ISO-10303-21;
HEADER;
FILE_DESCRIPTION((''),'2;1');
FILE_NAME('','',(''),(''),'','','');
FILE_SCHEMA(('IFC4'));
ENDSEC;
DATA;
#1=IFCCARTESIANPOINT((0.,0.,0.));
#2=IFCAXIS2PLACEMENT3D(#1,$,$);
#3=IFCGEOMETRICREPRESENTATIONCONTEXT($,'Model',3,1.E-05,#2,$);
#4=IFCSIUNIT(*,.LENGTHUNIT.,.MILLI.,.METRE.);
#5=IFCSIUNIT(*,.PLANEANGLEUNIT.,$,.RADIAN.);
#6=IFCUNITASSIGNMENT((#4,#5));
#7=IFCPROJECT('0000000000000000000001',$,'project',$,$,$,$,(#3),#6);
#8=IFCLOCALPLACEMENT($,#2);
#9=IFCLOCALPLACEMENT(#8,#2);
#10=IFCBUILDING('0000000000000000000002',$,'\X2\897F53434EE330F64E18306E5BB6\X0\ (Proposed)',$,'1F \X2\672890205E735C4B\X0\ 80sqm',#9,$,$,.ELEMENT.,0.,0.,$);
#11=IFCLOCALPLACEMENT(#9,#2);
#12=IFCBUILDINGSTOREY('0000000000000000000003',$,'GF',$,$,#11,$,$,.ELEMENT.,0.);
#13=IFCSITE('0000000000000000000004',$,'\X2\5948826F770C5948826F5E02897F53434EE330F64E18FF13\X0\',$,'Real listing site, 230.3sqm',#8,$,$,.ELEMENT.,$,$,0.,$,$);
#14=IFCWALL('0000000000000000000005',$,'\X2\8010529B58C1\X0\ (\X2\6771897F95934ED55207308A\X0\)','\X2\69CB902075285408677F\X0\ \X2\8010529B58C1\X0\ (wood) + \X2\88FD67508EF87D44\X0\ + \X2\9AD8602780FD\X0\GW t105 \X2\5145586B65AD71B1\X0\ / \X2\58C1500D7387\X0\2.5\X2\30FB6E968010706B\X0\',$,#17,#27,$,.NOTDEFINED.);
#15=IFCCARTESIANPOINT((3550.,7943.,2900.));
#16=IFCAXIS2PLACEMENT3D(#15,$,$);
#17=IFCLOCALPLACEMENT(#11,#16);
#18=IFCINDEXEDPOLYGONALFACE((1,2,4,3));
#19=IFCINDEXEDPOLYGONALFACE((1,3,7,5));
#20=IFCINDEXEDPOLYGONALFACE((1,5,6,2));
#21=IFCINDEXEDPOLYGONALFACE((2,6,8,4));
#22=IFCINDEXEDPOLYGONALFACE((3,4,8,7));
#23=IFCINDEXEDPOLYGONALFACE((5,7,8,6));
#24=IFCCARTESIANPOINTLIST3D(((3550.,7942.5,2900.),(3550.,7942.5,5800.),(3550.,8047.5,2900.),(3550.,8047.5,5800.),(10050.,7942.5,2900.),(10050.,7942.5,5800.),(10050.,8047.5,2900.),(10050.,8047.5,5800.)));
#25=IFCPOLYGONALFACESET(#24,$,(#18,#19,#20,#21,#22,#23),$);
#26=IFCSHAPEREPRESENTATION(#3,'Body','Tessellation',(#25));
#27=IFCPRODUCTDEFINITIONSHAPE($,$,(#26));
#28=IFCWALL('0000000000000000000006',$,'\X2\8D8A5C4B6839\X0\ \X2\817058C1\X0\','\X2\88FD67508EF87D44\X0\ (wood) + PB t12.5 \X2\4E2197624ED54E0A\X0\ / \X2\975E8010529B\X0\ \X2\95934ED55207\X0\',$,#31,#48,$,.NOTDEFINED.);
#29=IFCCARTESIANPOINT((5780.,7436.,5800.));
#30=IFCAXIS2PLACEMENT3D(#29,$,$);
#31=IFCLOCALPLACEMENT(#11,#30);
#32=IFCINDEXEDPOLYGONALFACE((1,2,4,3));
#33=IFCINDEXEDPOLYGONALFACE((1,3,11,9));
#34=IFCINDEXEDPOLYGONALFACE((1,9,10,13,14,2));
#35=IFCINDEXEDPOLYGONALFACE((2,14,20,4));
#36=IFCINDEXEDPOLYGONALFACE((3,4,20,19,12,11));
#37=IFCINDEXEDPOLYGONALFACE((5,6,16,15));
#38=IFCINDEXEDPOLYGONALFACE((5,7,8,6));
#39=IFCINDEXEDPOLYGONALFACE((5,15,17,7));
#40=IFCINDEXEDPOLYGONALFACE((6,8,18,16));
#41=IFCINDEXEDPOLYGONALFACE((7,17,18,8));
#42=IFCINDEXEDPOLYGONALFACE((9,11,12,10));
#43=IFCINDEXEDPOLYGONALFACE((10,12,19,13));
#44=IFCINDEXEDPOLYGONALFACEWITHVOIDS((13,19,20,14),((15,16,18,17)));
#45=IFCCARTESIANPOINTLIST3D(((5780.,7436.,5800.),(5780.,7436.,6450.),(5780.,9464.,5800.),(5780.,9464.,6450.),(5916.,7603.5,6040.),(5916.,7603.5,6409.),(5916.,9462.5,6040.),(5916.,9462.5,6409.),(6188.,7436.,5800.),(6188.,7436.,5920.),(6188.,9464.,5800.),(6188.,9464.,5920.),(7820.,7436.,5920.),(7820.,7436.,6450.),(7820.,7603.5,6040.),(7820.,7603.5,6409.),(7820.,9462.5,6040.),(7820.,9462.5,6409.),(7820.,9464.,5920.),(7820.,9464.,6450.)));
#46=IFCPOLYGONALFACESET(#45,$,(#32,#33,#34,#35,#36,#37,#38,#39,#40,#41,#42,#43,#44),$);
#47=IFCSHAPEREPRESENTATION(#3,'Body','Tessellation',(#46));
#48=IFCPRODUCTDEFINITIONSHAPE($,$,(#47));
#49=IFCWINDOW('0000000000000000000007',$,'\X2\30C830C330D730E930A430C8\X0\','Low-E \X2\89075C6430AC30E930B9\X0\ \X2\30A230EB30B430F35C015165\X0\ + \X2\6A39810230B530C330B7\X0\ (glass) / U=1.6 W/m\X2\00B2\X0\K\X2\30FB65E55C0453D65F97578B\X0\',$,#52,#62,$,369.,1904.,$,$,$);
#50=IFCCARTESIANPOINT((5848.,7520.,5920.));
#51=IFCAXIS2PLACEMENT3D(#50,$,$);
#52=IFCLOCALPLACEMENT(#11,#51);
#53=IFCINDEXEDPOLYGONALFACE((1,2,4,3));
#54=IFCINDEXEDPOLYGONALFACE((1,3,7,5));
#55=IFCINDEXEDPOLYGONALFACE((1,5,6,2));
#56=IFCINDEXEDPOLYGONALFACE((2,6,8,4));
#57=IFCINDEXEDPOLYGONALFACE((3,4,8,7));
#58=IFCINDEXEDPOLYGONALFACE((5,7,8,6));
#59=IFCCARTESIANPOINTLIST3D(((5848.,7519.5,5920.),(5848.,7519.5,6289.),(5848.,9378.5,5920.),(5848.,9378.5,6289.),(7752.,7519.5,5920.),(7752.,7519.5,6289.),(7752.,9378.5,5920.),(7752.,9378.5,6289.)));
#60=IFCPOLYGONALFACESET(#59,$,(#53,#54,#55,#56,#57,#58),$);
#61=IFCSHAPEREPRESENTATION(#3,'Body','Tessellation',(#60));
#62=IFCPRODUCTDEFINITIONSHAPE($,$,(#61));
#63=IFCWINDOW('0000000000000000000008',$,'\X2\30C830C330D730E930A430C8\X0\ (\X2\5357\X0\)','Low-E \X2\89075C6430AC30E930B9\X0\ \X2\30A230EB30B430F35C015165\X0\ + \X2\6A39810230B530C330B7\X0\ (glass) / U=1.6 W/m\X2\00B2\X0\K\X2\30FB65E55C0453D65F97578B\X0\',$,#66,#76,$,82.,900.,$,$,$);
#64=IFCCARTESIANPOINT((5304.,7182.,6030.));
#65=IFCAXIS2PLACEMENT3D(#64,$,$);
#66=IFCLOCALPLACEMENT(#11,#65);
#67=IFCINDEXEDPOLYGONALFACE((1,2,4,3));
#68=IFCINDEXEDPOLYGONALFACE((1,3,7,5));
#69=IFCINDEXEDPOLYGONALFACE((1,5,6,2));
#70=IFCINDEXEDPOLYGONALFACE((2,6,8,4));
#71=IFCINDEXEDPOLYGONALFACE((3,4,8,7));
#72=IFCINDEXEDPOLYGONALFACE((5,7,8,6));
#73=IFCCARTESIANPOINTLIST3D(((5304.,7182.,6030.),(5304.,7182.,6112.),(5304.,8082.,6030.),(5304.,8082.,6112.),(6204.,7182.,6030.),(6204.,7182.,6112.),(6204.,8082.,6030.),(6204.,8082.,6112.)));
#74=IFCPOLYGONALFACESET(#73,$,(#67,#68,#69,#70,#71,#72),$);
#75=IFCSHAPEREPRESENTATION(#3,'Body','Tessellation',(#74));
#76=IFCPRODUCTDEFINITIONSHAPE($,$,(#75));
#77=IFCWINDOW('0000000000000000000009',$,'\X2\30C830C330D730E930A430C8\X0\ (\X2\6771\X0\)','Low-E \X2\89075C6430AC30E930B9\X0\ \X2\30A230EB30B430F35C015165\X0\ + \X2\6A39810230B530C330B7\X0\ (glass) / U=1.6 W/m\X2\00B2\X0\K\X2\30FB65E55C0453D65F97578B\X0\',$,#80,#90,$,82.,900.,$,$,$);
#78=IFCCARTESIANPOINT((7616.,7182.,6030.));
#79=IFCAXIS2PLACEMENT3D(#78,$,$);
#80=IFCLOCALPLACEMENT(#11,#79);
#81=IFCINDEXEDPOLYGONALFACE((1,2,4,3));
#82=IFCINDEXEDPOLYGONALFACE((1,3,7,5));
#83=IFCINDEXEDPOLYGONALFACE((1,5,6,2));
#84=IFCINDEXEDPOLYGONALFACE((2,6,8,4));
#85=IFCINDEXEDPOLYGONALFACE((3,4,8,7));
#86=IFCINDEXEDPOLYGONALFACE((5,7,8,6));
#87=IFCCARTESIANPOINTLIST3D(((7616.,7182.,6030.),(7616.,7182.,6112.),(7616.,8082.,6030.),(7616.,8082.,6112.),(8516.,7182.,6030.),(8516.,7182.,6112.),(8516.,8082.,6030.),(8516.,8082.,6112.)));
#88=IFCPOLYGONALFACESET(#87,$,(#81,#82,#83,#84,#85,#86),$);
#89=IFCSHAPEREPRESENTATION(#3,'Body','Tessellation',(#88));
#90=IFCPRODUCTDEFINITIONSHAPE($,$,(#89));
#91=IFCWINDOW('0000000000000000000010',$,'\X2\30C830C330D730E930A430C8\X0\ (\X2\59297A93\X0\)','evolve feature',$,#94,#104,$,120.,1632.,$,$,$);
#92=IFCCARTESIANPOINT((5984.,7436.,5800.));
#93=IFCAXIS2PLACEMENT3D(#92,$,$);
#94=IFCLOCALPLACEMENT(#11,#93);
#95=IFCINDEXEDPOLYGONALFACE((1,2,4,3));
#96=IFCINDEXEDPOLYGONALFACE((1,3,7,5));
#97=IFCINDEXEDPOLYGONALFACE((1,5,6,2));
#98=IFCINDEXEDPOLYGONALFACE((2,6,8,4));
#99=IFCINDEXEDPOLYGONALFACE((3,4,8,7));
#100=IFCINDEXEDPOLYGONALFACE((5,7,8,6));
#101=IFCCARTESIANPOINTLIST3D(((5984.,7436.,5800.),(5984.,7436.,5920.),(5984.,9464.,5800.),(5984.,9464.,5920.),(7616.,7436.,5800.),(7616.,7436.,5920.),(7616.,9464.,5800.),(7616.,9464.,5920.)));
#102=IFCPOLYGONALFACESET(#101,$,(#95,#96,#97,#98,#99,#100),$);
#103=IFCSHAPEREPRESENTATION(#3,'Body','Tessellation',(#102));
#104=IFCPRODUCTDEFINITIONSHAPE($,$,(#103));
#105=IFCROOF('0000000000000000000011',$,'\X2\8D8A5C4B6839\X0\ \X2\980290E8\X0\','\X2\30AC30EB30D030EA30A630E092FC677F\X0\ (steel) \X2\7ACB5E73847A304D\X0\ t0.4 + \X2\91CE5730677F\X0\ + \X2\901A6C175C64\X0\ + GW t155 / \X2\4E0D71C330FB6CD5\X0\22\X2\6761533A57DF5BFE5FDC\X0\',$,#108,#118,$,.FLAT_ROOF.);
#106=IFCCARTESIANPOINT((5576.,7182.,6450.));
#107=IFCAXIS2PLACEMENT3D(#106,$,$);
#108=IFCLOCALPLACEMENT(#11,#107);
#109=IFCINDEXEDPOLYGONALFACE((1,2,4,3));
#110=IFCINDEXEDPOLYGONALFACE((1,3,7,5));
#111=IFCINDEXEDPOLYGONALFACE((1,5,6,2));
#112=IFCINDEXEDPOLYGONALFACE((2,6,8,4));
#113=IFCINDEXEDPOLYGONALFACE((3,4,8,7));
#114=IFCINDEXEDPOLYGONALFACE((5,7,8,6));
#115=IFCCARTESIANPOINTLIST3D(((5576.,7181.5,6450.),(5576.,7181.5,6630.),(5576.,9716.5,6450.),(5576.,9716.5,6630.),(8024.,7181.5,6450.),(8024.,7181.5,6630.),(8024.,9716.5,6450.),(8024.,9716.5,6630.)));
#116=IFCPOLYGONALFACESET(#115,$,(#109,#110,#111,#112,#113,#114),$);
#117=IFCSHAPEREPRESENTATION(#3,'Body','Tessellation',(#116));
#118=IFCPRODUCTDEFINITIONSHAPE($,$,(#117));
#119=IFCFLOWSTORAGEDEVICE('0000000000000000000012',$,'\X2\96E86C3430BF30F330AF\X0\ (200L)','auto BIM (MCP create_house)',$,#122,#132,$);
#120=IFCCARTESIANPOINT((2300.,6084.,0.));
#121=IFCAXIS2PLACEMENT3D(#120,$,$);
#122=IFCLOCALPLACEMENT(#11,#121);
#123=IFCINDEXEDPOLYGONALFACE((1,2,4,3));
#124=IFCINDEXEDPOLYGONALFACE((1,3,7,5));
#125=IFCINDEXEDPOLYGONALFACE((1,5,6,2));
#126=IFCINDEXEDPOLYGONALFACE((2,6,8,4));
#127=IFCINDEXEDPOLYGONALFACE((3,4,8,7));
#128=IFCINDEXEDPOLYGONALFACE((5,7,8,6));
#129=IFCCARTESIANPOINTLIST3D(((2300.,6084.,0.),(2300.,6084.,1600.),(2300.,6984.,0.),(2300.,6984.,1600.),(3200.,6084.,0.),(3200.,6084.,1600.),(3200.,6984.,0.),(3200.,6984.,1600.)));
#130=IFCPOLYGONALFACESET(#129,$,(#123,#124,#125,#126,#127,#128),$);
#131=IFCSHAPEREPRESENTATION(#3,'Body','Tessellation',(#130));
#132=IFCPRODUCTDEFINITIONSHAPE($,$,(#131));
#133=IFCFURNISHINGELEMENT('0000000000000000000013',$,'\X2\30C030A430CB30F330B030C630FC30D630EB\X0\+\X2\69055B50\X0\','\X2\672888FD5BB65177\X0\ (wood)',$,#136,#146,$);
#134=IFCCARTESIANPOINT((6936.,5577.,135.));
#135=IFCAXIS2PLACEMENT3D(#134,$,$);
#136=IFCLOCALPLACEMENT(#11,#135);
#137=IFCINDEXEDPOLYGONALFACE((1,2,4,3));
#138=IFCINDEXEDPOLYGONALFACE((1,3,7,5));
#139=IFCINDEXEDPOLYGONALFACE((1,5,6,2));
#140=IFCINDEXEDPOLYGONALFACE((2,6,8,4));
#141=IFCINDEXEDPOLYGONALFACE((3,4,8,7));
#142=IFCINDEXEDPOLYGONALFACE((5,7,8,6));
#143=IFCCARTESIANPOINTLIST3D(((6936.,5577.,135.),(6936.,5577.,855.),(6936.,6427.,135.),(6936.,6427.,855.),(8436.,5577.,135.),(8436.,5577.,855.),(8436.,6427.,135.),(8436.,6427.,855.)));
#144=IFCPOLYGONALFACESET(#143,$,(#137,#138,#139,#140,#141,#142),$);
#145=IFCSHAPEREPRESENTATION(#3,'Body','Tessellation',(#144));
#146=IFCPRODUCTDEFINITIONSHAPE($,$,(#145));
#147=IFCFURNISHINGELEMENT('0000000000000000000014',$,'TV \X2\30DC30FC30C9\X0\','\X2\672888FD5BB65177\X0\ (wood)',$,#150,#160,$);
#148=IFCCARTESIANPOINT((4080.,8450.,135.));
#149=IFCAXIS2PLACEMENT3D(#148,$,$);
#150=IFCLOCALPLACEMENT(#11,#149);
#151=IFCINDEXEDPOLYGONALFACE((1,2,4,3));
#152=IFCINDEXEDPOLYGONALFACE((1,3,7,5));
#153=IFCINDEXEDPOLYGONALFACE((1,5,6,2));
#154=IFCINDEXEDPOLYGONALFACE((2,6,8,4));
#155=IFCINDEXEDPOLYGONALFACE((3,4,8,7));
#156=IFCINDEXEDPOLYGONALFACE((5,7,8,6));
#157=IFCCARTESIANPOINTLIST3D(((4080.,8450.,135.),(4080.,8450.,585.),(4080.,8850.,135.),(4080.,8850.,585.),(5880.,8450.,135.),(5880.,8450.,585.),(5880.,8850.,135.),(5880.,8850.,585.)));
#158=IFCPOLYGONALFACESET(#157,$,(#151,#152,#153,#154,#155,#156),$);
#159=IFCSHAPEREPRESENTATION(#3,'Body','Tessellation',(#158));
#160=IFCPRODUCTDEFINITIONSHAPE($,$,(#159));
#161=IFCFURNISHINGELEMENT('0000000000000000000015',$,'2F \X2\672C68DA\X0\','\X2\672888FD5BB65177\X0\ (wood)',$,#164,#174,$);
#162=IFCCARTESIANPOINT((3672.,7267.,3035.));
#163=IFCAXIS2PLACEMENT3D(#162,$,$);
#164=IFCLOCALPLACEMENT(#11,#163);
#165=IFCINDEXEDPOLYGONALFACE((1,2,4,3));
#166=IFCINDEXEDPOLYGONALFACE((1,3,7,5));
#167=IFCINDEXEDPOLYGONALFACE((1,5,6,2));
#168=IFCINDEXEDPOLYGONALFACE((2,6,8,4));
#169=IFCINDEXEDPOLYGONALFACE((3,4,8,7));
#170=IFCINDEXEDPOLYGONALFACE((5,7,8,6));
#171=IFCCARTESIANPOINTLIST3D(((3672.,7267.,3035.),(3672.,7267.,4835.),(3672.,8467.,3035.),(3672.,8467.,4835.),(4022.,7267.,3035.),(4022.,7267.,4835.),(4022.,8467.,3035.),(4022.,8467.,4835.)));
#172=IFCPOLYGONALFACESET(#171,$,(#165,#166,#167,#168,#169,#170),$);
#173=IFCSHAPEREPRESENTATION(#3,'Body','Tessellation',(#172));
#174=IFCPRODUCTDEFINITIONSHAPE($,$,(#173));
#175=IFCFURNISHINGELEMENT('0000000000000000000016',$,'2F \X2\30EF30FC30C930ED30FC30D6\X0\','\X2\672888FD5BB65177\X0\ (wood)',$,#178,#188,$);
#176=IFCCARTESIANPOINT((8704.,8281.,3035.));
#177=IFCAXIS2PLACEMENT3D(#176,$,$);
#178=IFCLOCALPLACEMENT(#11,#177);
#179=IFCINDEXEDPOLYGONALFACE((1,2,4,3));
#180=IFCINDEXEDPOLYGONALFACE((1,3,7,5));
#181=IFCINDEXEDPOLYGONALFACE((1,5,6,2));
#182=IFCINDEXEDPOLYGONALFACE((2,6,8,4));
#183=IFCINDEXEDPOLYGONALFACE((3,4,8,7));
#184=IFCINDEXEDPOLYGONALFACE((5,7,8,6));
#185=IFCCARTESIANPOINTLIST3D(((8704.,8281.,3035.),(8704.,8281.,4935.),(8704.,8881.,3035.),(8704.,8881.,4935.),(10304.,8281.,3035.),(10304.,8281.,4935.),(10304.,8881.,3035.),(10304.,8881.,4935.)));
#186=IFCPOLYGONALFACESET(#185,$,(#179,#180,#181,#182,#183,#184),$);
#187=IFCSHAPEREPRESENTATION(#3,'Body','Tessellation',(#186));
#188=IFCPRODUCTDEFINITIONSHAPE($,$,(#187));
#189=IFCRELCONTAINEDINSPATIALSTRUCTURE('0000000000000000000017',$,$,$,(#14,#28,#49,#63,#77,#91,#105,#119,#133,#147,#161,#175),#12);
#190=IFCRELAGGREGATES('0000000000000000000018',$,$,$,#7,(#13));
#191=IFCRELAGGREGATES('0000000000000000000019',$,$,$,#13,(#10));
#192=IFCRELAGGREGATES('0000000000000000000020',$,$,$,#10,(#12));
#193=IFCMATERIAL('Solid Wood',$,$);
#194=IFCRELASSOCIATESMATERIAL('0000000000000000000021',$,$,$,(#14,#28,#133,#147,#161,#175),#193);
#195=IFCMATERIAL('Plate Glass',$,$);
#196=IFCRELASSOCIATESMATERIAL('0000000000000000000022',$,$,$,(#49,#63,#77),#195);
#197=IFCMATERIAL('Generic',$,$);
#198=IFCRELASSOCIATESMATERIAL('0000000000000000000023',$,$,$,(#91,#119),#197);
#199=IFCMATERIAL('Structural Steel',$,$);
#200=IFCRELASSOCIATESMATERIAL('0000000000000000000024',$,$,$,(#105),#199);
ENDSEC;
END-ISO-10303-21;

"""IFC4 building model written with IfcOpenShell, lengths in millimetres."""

from ifc_helpers import new_model, si_unit, frame, frame_2d, origin, place, context, project, spatial, rectangle, extrude, material, element, fill, save


model = new_model("IFC4")

# Units and contexts
model_context = context("Model", 3, precision=1e-05, world=origin())
ifc_project = project(units=[si_unit("LENGTHUNIT", "METRE", prefix="MILLI"), si_unit("PLANEANGLEUNIT", "RADIAN")], contexts=[model_context])

# Site, building, storey
site_placement = place(None, origin())
site = spatial("IfcSite", under=ifc_project, at=site_placement, Name="奈良県奈良市西千代ヶ丘３", ObjectType="Real listing site, 230.3sqm", CompositionType="ELEMENT", RefElevation=0.0)
building_placement = place(site_placement, origin())
building = spatial("IfcBuilding", under=site, at=building_placement, Name="西千代ヶ丘の家 (Proposed)", ObjectType="1F 木造平屋 80sqm", CompositionType="ELEMENT", ElevationOfRefHeight=0.0, ElevationOfTerrain=0.0)
storey_placement = place(building_placement, origin())
storey = spatial("IfcBuildingStorey", under=building, at=storey_placement, Name="GF", CompositionType="ELEMENT", Elevation=0.0)

# Wall
ifc_material_1 = material(Name="Solid Wood")
wall_1_placement = place(storey_placement, frame((3550.0, 7943.0, 2900.0)))
element("IfcWall", 1, at=wall_1_placement, inside=storey, material=ifc_material_1, Name="耐力壁 (東西間仕切り)", Description="構造用合板 耐力壁 (wood) + 製材軸組 + 高性能GW t105 充填断熱 / 壁倍率2.5・準耐火", PredefinedType="NOTDEFINED", context=model_context, shape_type="SweptSolid", body=[
    extrude(rectangle(XDim=6500.0, YDim=105.0, at=frame_2d((3250.0, 52.0))), frame((3550.0, 7943.0, 2900.0)), (0.0, 0.0, 1.0), 2900.0),
])

# Wall, openings, windows
wall_2_placement = place(storey_placement, frame((5780.0, 7436.0, 5800.0)))
wall_2 = element("IfcWall", 2, at=wall_2_placement, inside=storey, material=ifc_material_1, Name="越屋根 腰壁", Description="製材軸組 (wood) + PB t12.5 両面仕上 / 非耐力 間仕切", PredefinedType="NOTDEFINED", context=model_context, shape_type="SweptSolid", body=[
    extrude(rectangle(XDim=2040.0, YDim=2028.0, at=frame_2d((1020.0, 1014.0))), frame((5780.0, 7436.0, 5800.0)), (0.0, 0.0, 1.0), 650.0),
])
opening_1_placement = place(storey_placement, frame((5848.0, 7520.0, 5920.0)))
opening_1 = element("IfcOpeningElement", 3, at=opening_1_placement, cuts=wall_2, PredefinedType="NOTDEFINED", context=model_context, shape_type="SweptSolid", body=[
    extrude(rectangle(XDim=1904.0, YDim=1859.0, at=frame_2d((952.0, 929.0))), frame((5848.0, 7520.0, 5920.0)), (0.0, 0.0, 1.0), 369.0),
])
opening_2_placement = place(storey_placement, frame((5304.0, 7182.0, 6030.0)))
opening_2 = element("IfcOpeningElement", 4, at=opening_2_placement, cuts=wall_2, PredefinedType="NOTDEFINED", context=model_context, shape_type="SweptSolid", body=[
    extrude(rectangle(XDim=900.0, YDim=900.0, at=frame_2d((450.0, 450.0))), frame((5304.0, 7182.0, 6030.0)), (0.0, 0.0, 1.0), 82.0),
])
opening_3_placement = place(storey_placement, frame((7616.0, 7182.0, 6030.0)))
opening_3 = element("IfcOpeningElement", 5, at=opening_3_placement, cuts=wall_2, PredefinedType="NOTDEFINED", context=model_context, shape_type="SweptSolid", body=[
    extrude(rectangle(XDim=900.0, YDim=900.0, at=frame_2d((450.0, 450.0))), frame((7616.0, 7182.0, 6030.0)), (0.0, 0.0, 1.0), 82.0),
])
opening_4_placement = place(storey_placement, frame((5984.0, 7436.0, 5800.0)))
opening_4 = element("IfcOpeningElement", 6, at=opening_4_placement, cuts=wall_2, PredefinedType="NOTDEFINED", context=model_context, shape_type="SweptSolid", body=[
    extrude(rectangle(XDim=1632.0, YDim=2028.0, at=frame_2d((816.0, 1014.0))), frame((5984.0, 7436.0, 5800.0)), (0.0, 0.0, 1.0), 120.0),
])
ifc_material_2 = material(Name="Plate Glass")
window_1_placement = place(storey_placement, frame((5848.0, 7520.0, 5920.0)))
window_1 = element("IfcWindow", 7, at=window_1_placement, inside=storey, material=ifc_material_2, Name="トップライト", Description="Low-E 複層ガラス アルゴン封入 + 樹脂サッシ (glass) / U=1.6 W/m²K・日射取得型", OverallHeight=369.0, OverallWidth=1904.0, context=model_context, shape_type="SweptSolid", body=[
    extrude(rectangle(XDim=1904.0, YDim=1859.0, at=frame_2d((952.0, 929.0))), frame((5848.0, 7520.0, 5920.0)), (0.0, 0.0, 1.0), 369.0),
])
fill(opening_1, window_1)
window_2_placement = place(storey_placement, frame((5304.0, 7182.0, 6030.0)))
window_2 = element("IfcWindow", 8, at=window_2_placement, inside=storey, material=ifc_material_2, Name="トップライト (南)", Description="Low-E 複層ガラス アルゴン封入 + 樹脂サッシ (glass) / U=1.6 W/m²K・日射取得型", OverallHeight=82.0, OverallWidth=900.0, context=model_context, shape_type="SweptSolid", body=[
    extrude(rectangle(XDim=900.0, YDim=900.0, at=frame_2d((450.0, 450.0))), frame((5304.0, 7182.0, 6030.0)), (0.0, 0.0, 1.0), 82.0),
])
fill(opening_2, window_2)
window_3_placement = place(storey_placement, frame((7616.0, 7182.0, 6030.0)))
window_3 = element("IfcWindow", 9, at=window_3_placement, inside=storey, material=ifc_material_2, Name="トップライト (東)", Description="Low-E 複層ガラス アルゴン封入 + 樹脂サッシ (glass) / U=1.6 W/m²K・日射取得型", OverallHeight=82.0, OverallWidth=900.0, context=model_context, shape_type="SweptSolid", body=[
    extrude(rectangle(XDim=900.0, YDim=900.0, at=frame_2d((450.0, 450.0))), frame((7616.0, 7182.0, 6030.0)), (0.0, 0.0, 1.0), 82.0),
])
fill(opening_3, window_3)
ifc_material_3 = material(Name="Generic")
window_4_placement = place(storey_placement, frame((5984.0, 7436.0, 5800.0)))
window_4 = element("IfcWindow", 10, at=window_4_placement, inside=storey, material=ifc_material_3, Name="トップライト (天窓)", Description="evolve feature", OverallHeight=120.0, OverallWidth=1632.0, context=model_context, shape_type="SweptSolid", body=[
    extrude(rectangle(XDim=1632.0, YDim=2028.0, at=frame_2d((816.0, 1014.0))), frame((5984.0, 7436.0, 5800.0)), (0.0, 0.0, 1.0), 120.0),
])
fill(opening_4, window_4)

# Roof
ifc_material_4 = material(Name="Structural Steel")
roof_placement = place(storey_placement, frame((5576.0, 7182.0, 6450.0)))
element("IfcRoof", 11, at=roof_placement, inside=storey, material=ifc_material_4, Name="越屋根 頂部", Description="ガルバリウム鋼板 (steel) 立平葺き t0.4 + 野地板 + 通気層 + GW t155 / 不燃・法22条区域対応", PredefinedType="FLAT_ROOF", context=model_context, shape_type="SweptSolid", body=[
    extrude(rectangle(XDim=2448.0, YDim=2535.0, at=frame_2d((1224.0, 1267.0))), frame((5576.0, 7182.0, 6450.0)), (0.0, 0.0, 1.0), 180.0),
])

# Flow storage device
flow_storage_device_placement = place(storey_placement, frame((2300.0, 6084.0, 0.0)))
element("IfcFlowStorageDevice", 12, at=flow_storage_device_placement, inside=storey, material=ifc_material_3, Name="雨水タンク (200L)", Description="auto BIM (MCP create_house)", context=model_context, shape_type="SweptSolid", body=[
    extrude(rectangle(XDim=900.0, YDim=900.0, at=frame_2d((450.0, 450.0))), frame((2300.0, 6084.0, 0.0)), (0.0, 0.0, 1.0), 1600.0),
])

# Furnishing elements
furnishing_1_placement = place(storey_placement, frame((6936.0, 5577.0, 135.0)))
element("IfcFurnishingElement", 13, at=furnishing_1_placement, inside=storey, material=ifc_material_1, Name="ダイニングテーブル+椅子", Description="木製家具 (wood)", context=model_context, shape_type="SweptSolid", body=[
    extrude(rectangle(XDim=1500.0, YDim=850.0, at=frame_2d((750.0, 425.0))), frame((6936.0, 5577.0, 135.0)), (0.0, 0.0, 1.0), 720.0),
])
furnishing_2_placement = place(storey_placement, frame((4080.0, 8450.0, 135.0)))
element("IfcFurnishingElement", 14, at=furnishing_2_placement, inside=storey, material=ifc_material_1, Name="TV ボード", Description="木製家具 (wood)", context=model_context, shape_type="SweptSolid", body=[
    extrude(rectangle(XDim=1800.0, YDim=400.0, at=frame_2d((900.0, 200.0))), frame((4080.0, 8450.0, 135.0)), (0.0, 0.0, 1.0), 450.0),
])
furnishing_3_placement = place(storey_placement, frame((3672.0, 7267.0, 3035.0)))
element("IfcFurnishingElement", 15, at=furnishing_3_placement, inside=storey, material=ifc_material_1, Name="2F 本棚", Description="木製家具 (wood)", context=model_context, shape_type="SweptSolid", body=[
    extrude(rectangle(XDim=350.0, YDim=1200.0, at=frame_2d((175.0, 600.0))), frame((3672.0, 7267.0, 3035.0)), (0.0, 0.0, 1.0), 1800.0),
])
furnishing_4_placement = place(storey_placement, frame((8704.0, 8281.0, 3035.0)))
element("IfcFurnishingElement", 16, at=furnishing_4_placement, inside=storey, material=ifc_material_1, Name="2F ワードローブ", Description="木製家具 (wood)", context=model_context, shape_type="SweptSolid", body=[
    extrude(rectangle(XDim=1600.0, YDim=600.0, at=frame_2d((800.0, 300.0))), frame((8704.0, 8281.0, 3035.0)), (0.0, 0.0, 1.0), 1900.0),
])

save(model, "model.ifc")
